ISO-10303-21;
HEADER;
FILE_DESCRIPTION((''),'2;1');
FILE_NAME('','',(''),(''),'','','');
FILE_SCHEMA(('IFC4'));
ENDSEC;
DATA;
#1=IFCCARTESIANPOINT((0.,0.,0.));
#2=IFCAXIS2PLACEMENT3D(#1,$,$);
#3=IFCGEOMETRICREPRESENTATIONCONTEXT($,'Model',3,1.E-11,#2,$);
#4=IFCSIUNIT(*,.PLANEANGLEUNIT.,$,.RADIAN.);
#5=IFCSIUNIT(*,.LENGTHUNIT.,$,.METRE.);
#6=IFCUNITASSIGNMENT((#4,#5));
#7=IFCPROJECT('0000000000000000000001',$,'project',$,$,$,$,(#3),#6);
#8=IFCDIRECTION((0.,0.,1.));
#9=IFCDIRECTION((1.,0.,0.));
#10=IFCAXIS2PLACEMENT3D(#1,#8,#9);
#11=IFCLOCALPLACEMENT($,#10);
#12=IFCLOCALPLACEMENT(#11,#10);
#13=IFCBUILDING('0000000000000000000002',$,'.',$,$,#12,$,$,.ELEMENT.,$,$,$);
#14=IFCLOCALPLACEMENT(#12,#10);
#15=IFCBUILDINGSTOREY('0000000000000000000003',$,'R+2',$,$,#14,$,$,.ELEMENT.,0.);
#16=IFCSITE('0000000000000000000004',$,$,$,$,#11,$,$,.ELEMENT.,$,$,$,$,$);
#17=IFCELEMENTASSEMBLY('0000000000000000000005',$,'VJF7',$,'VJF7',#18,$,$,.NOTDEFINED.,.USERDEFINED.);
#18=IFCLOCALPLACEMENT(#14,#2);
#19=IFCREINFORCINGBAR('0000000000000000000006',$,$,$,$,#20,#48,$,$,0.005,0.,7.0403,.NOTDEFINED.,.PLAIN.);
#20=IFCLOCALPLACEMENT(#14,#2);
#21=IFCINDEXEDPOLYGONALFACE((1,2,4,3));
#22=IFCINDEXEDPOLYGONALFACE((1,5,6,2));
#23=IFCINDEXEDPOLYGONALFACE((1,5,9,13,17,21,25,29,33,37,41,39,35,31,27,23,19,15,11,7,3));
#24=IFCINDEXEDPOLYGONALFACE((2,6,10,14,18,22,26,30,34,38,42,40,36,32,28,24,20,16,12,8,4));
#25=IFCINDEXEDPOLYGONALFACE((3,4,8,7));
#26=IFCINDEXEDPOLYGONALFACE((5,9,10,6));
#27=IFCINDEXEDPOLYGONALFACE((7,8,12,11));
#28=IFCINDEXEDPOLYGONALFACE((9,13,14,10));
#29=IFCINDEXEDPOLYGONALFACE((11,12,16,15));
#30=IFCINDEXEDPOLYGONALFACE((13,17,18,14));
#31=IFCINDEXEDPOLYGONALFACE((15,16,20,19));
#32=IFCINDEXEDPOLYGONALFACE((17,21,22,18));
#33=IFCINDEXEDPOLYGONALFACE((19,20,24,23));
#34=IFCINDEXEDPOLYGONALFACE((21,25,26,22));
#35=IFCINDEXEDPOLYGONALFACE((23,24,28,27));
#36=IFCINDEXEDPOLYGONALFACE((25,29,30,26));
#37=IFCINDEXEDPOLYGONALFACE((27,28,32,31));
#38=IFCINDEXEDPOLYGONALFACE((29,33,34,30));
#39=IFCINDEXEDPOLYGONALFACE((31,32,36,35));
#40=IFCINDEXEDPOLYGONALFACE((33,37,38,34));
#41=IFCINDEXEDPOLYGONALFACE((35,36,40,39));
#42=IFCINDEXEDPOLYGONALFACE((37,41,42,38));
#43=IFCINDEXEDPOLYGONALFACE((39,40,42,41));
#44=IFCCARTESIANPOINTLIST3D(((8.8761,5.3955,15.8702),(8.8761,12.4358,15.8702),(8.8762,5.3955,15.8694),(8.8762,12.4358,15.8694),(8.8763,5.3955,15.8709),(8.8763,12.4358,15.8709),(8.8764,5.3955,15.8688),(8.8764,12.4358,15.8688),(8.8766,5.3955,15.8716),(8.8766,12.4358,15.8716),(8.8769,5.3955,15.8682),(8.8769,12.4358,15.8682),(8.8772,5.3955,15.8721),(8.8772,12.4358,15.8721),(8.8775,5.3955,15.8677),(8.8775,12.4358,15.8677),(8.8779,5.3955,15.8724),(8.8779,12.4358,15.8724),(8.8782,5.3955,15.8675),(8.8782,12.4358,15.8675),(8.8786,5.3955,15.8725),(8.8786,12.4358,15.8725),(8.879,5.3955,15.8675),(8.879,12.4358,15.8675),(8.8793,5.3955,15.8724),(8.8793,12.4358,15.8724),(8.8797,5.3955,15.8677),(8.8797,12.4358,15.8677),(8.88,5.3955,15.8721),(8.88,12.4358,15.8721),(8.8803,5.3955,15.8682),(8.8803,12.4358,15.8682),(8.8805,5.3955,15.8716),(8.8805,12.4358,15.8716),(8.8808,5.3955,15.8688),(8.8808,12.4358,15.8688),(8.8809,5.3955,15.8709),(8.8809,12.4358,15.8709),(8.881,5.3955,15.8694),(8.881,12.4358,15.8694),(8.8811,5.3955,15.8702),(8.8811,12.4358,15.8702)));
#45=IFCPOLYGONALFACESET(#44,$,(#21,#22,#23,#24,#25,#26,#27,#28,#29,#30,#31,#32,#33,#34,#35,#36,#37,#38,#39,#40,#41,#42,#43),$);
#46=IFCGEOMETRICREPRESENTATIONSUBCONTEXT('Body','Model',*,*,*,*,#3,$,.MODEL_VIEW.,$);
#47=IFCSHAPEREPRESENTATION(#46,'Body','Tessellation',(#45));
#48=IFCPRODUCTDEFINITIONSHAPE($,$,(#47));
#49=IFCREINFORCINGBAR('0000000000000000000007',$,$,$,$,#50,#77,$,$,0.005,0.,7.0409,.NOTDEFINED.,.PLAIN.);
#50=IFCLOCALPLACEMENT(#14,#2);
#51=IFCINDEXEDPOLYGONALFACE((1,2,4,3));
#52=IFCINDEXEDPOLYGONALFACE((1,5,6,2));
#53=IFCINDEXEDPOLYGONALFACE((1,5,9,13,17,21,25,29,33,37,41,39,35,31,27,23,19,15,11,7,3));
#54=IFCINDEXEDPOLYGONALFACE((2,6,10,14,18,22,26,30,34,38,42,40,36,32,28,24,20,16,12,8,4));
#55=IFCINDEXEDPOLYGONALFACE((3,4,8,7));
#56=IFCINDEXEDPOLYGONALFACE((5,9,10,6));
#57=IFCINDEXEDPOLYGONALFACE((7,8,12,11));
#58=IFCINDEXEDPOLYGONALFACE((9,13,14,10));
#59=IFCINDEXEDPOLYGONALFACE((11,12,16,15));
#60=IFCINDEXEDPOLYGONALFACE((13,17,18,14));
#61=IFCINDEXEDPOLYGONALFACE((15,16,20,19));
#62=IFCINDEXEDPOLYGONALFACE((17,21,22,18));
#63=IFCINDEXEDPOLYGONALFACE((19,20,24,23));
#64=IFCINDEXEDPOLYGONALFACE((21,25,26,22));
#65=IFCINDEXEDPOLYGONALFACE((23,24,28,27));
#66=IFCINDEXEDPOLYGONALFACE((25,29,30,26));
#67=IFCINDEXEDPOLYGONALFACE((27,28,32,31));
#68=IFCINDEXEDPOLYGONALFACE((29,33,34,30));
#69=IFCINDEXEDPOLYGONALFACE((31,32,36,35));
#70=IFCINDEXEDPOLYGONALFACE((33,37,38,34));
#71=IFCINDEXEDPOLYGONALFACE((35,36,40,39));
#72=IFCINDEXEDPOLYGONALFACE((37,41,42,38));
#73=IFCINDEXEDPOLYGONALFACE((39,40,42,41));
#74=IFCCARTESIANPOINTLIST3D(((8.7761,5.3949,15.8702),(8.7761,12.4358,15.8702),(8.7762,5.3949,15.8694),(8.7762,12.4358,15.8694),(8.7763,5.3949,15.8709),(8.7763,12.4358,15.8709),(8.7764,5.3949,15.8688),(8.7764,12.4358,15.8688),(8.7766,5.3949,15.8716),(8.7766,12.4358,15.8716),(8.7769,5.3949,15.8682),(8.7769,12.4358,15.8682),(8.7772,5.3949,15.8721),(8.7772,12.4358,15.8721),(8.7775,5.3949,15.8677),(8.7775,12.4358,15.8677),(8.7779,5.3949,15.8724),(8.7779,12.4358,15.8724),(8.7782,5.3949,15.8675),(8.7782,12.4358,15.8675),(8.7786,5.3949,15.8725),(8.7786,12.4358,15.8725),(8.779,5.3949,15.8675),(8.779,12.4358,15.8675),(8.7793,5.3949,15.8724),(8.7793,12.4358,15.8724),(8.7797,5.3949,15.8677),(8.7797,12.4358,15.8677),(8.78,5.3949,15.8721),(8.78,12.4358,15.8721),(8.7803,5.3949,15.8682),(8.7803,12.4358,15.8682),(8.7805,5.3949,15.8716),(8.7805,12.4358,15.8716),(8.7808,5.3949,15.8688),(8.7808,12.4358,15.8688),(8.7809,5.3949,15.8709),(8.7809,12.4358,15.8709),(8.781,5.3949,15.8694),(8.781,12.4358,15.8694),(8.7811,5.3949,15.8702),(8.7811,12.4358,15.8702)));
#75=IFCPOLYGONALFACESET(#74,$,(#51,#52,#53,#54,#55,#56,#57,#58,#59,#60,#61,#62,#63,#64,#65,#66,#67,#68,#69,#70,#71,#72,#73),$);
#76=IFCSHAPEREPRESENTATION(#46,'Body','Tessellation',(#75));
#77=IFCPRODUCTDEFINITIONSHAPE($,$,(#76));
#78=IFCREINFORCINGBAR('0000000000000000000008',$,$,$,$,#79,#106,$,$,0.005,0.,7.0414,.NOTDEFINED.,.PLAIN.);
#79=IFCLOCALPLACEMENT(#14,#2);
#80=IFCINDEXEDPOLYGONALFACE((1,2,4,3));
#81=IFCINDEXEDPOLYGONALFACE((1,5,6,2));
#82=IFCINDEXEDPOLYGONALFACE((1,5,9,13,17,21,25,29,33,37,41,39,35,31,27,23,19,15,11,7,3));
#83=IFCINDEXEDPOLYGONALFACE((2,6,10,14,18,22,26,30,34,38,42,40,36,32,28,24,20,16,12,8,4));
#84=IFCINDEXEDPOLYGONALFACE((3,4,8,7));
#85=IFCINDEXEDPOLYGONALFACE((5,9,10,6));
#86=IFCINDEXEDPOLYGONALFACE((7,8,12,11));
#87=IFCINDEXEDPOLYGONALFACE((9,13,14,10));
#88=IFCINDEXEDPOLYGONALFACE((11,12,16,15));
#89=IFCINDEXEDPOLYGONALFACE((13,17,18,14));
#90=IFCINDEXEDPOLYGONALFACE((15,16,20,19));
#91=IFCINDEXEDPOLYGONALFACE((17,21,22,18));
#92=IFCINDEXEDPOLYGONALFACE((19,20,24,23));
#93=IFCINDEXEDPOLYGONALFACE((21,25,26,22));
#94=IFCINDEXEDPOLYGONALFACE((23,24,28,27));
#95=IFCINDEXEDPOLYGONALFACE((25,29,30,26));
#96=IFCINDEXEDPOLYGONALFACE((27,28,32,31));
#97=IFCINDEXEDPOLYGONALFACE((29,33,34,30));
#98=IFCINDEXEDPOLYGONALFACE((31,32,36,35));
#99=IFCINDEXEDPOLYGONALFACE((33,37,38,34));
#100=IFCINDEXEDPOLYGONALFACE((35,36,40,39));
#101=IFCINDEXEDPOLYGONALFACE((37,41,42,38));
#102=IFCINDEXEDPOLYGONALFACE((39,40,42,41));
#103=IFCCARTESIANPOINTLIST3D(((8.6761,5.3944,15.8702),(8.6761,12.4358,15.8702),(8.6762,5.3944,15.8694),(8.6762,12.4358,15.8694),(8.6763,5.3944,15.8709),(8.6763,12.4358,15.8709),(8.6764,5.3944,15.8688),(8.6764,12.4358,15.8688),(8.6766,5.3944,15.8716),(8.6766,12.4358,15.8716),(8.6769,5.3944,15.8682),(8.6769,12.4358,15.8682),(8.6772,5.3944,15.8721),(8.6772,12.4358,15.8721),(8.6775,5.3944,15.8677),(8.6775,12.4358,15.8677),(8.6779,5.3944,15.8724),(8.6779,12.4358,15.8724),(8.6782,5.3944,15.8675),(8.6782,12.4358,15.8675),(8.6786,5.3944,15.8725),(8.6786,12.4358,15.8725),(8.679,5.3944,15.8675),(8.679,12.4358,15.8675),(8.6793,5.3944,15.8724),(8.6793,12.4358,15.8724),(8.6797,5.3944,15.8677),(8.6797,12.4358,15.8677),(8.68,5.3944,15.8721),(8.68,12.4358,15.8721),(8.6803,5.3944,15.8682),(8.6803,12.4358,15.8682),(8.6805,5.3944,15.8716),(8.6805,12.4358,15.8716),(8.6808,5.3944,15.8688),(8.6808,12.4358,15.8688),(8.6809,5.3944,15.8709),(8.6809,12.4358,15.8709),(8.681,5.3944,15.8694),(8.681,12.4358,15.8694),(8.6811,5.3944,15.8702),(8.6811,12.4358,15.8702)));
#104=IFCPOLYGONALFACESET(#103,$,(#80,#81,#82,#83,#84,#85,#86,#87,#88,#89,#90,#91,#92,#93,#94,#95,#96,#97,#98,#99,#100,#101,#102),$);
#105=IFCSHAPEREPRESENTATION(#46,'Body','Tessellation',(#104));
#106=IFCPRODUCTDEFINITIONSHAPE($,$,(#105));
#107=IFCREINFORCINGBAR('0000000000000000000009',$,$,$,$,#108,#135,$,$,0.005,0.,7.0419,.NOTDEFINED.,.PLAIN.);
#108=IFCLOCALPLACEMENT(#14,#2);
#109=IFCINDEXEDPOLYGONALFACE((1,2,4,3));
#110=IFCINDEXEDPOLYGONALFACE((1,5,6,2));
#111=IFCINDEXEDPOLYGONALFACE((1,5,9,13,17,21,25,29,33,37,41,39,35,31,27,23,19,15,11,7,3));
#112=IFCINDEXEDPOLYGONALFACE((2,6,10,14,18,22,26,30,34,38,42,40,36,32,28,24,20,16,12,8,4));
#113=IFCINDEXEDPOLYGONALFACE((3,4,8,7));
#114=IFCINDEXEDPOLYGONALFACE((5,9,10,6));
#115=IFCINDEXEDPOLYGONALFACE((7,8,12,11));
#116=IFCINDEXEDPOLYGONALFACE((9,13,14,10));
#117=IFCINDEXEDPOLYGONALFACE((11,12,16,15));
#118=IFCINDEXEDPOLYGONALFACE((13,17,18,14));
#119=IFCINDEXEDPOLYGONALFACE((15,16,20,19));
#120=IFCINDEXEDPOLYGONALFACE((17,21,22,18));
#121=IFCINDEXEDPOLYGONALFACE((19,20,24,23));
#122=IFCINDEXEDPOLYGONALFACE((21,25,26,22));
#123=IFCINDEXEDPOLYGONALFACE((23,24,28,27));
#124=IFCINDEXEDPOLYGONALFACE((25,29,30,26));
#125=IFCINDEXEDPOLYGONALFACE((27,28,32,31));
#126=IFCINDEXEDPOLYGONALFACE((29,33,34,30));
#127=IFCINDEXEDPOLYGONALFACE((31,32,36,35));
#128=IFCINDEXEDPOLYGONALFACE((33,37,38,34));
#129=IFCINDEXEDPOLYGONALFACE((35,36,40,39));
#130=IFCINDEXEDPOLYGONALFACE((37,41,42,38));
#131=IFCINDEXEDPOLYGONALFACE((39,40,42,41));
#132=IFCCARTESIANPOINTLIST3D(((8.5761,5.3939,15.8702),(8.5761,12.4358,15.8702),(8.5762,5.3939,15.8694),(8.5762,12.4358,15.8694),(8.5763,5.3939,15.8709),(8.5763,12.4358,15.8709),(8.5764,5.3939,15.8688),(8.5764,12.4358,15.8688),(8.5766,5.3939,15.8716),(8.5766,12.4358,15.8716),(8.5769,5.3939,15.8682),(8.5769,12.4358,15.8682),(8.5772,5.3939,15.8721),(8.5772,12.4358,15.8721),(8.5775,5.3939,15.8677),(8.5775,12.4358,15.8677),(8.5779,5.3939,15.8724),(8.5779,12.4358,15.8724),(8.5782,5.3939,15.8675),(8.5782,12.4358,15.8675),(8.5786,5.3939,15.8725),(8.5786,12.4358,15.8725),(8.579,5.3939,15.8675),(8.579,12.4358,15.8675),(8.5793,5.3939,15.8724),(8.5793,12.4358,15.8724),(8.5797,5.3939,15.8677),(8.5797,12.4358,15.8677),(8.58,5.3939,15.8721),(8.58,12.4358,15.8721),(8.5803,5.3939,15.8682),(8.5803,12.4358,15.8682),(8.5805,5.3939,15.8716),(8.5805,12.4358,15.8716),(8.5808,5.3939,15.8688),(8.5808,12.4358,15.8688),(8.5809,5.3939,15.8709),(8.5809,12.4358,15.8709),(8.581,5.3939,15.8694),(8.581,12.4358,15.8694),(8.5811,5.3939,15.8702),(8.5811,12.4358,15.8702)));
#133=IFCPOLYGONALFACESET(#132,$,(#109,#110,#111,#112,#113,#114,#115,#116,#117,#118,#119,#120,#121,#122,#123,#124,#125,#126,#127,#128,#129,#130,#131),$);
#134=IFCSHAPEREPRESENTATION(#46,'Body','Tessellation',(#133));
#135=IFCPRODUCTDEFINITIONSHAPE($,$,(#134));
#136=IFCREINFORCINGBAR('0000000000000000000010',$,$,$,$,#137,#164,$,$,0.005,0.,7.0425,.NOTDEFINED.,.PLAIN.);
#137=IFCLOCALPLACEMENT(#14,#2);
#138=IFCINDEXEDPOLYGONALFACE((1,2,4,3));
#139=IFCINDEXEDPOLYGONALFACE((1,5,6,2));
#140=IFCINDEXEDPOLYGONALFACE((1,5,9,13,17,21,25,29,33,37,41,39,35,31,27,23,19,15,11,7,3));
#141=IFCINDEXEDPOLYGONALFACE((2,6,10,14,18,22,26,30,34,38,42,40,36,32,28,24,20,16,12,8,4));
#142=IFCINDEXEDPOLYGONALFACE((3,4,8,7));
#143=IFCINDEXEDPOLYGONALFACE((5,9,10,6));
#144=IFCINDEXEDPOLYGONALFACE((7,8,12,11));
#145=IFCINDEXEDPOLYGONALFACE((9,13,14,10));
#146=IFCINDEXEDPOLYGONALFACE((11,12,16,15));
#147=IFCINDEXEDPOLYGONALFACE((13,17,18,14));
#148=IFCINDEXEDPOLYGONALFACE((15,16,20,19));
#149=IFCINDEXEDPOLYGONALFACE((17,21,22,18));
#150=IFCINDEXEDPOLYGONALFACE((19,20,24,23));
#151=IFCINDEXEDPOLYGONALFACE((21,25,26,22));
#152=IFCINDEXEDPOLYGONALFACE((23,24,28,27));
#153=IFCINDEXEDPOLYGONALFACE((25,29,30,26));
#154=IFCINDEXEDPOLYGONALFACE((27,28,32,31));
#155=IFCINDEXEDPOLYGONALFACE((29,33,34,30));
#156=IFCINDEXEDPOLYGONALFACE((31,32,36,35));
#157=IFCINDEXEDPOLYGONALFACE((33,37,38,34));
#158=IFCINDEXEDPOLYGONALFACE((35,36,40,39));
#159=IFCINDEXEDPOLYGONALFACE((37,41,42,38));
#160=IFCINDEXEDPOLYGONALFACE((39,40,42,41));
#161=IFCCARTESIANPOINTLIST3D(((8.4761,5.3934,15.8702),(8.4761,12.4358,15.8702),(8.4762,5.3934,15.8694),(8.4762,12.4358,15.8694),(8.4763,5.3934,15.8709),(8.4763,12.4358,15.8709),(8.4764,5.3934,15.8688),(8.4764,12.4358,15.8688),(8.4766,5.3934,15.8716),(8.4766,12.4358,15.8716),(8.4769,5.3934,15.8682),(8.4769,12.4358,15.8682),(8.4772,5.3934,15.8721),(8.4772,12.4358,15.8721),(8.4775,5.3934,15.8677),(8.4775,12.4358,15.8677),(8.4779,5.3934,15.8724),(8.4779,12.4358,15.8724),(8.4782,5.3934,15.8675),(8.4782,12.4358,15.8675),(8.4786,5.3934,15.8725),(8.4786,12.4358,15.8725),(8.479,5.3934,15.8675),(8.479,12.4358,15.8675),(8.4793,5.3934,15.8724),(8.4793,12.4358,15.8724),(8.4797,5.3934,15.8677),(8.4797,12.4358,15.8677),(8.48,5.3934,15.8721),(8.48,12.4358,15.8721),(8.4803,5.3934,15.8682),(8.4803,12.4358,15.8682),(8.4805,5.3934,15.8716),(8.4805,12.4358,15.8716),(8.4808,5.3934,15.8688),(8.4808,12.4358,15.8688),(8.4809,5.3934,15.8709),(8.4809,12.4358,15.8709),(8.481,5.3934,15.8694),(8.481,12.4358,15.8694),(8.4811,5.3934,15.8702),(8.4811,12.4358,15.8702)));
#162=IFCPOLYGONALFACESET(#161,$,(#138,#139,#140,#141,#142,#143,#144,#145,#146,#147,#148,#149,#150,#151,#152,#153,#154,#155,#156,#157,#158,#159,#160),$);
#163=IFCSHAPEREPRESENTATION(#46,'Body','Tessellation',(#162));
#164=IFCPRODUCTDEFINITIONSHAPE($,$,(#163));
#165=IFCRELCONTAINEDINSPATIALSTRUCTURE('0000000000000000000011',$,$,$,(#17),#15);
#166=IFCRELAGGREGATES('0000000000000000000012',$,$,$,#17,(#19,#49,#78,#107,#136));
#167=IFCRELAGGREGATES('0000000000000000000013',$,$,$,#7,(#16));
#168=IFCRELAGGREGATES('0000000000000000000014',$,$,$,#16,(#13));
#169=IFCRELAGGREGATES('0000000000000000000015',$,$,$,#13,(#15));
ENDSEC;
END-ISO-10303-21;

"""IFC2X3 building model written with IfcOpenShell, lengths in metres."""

from ifc_helpers import new_model, entity, si_unit, origin, origin_with_axes, place, context, subcontext, project, spatial, shape, element, aggregate, save


model = new_model("IFC2X3")

# Units and contexts
model_context = context("Model", 3, precision=1e-11, world=origin())
body_context = subcontext(model_context, "Body", "Model", "MODEL_VIEW")
ifc_project = project(units=[si_unit("PLANEANGLEUNIT", "RADIAN"), si_unit("LENGTHUNIT", "METRE")], contexts=[model_context])

# Site, building, storey
site_placement = place(None, origin_with_axes())
site = spatial("IfcSite", under=ifc_project, at=site_placement, CompositionType="ELEMENT")
building_placement = place(site_placement, origin_with_axes())
building = spatial("IfcBuilding", under=site, at=building_placement, Name=".", CompositionType="ELEMENT")
storey_placement = place(building_placement, origin_with_axes())
storey = spatial("IfcBuildingStorey", under=building, at=storey_placement, Name="R+2", CompositionType="ELEMENT", Elevation=0.0)

# Element assembly, reinforcing bars
assembly_1_placement = place(storey_placement, origin_with_axes())
assembly_1 = element("IfcElementAssembly", 1, at=assembly_1_placement, inside=storey, Name="VJF7", ObjectType="VJF7", AssemblyPlace="NOTDEFINED", PredefinedType="USERDEFINED")
reinforcing_bar_1_placement = place(assembly_1_placement, origin_with_axes())
reinforcing_bar_1 = element("IfcReinforcingBar", 2, at=reinforcing_bar_1_placement, BarLength=7.0403, BarRole="NOTDEFINED", BarSurface="PLAIN", CrossSectionArea=0.0, NominalDiameter=0.005, shapes=[
    shape(body_context, "Body", "AdvancedSweptSolid", [entity("IfcSweptDiskSolid", entity("IfcPolyline", [entity("IfcCartesianPoint", [8.8786, 5.3955, 15.87]), entity("IfcCartesianPoint", [8.8786, 12.4358, 15.87])]), 0.0025, None, 0.0, 7.0403)]),
    shape(body_context, "Body", "AdvancedSweptSolid", [entity("IfcSweptDiskSolid", entity("IfcPolyline", [entity("IfcCartesianPoint", [8.8786, 5.3955, 15.87]), entity("IfcCartesianPoint", [8.8786, 12.4358, 15.87])]), 0.0025, None, 0.0, 7.0403)]),
])
reinforcing_bar_2_placement = place(assembly_1_placement, origin_with_axes())
reinforcing_bar_2 = element("IfcReinforcingBar", 3, at=reinforcing_bar_2_placement, BarLength=7.0409, BarRole="NOTDEFINED", BarSurface="PLAIN", CrossSectionArea=0.0, NominalDiameter=0.005, shapes=[
    shape(body_context, "Body", "AdvancedSweptSolid", [entity("IfcSweptDiskSolid", entity("IfcPolyline", [entity("IfcCartesianPoint", [8.7786, 5.3949, 15.87]), entity("IfcCartesianPoint", [8.7786, 12.4358, 15.87])]), 0.0025, None, 0.0, 7.0409)]),
    shape(body_context, "Body", "AdvancedSweptSolid", [entity("IfcSweptDiskSolid", entity("IfcPolyline", [entity("IfcCartesianPoint", [8.7786, 5.3949, 15.87]), entity("IfcCartesianPoint", [8.7786, 12.4358, 15.87])]), 0.0025, None, 0.0, 7.0409)]),
])
reinforcing_bar_3_placement = place(assembly_1_placement, origin_with_axes())
reinforcing_bar_3 = element("IfcReinforcingBar", 4, at=reinforcing_bar_3_placement, BarLength=7.0414, BarRole="NOTDEFINED", BarSurface="PLAIN", CrossSectionArea=0.0, NominalDiameter=0.005, shapes=[
    shape(body_context, "Body", "AdvancedSweptSolid", [entity("IfcSweptDiskSolid", entity("IfcPolyline", [entity("IfcCartesianPoint", [8.6786, 5.3944, 15.87]), entity("IfcCartesianPoint", [8.6786, 12.4358, 15.87])]), 0.0025, None, 0.0, 7.0414)]),
    shape(body_context, "Body", "AdvancedSweptSolid", [entity("IfcSweptDiskSolid", entity("IfcPolyline", [entity("IfcCartesianPoint", [8.6786, 5.3944, 15.87]), entity("IfcCartesianPoint", [8.6786, 12.4358, 15.87])]), 0.0025, None, 0.0, 7.0414)]),
])
reinforcing_bar_4_placement = place(assembly_1_placement, origin_with_axes())
reinforcing_bar_4 = element("IfcReinforcingBar", 5, at=reinforcing_bar_4_placement, BarLength=7.0419, BarRole="NOTDEFINED", BarSurface="PLAIN", CrossSectionArea=0.0, NominalDiameter=0.005, shapes=[
    shape(body_context, "Body", "AdvancedSweptSolid", [entity("IfcSweptDiskSolid", entity("IfcPolyline", [entity("IfcCartesianPoint", [8.5786, 5.3939, 15.87]), entity("IfcCartesianPoint", [8.5786, 12.4358, 15.87])]), 0.0025, None, 0.0, 7.0419)]),
    shape(body_context, "Body", "AdvancedSweptSolid", [entity("IfcSweptDiskSolid", entity("IfcPolyline", [entity("IfcCartesianPoint", [8.5786, 5.3939, 15.87]), entity("IfcCartesianPoint", [8.5786, 12.4358, 15.87])]), 0.0025, None, 0.0, 7.0419)]),
])
reinforcing_bar_5_placement = place(assembly_1_placement, origin_with_axes())
reinforcing_bar_5 = element("IfcReinforcingBar", 6, at=reinforcing_bar_5_placement, BarLength=7.0425, BarRole="NOTDEFINED", BarSurface="PLAIN", CrossSectionArea=0.0, NominalDiameter=0.005, shapes=[
    shape(body_context, "Body", "AdvancedSweptSolid", [entity("IfcSweptDiskSolid", entity("IfcPolyline", [entity("IfcCartesianPoint", [8.4786, 5.3934, 15.87]), entity("IfcCartesianPoint", [8.4786, 12.4358, 15.87])]), 0.0025, None, 0.0, 7.0425)]),
    shape(body_context, "Body", "AdvancedSweptSolid", [entity("IfcSweptDiskSolid", entity("IfcPolyline", [entity("IfcCartesianPoint", [8.4786, 5.3934, 15.87]), entity("IfcCartesianPoint", [8.4786, 12.4358, 15.87])]), 0.0025, None, 0.0, 7.0425)]),
])
aggregate(assembly_1, [reinforcing_bar_1, reinforcing_bar_2, reinforcing_bar_3, reinforcing_bar_4, reinforcing_bar_5])

save(model, "model.ifc")
